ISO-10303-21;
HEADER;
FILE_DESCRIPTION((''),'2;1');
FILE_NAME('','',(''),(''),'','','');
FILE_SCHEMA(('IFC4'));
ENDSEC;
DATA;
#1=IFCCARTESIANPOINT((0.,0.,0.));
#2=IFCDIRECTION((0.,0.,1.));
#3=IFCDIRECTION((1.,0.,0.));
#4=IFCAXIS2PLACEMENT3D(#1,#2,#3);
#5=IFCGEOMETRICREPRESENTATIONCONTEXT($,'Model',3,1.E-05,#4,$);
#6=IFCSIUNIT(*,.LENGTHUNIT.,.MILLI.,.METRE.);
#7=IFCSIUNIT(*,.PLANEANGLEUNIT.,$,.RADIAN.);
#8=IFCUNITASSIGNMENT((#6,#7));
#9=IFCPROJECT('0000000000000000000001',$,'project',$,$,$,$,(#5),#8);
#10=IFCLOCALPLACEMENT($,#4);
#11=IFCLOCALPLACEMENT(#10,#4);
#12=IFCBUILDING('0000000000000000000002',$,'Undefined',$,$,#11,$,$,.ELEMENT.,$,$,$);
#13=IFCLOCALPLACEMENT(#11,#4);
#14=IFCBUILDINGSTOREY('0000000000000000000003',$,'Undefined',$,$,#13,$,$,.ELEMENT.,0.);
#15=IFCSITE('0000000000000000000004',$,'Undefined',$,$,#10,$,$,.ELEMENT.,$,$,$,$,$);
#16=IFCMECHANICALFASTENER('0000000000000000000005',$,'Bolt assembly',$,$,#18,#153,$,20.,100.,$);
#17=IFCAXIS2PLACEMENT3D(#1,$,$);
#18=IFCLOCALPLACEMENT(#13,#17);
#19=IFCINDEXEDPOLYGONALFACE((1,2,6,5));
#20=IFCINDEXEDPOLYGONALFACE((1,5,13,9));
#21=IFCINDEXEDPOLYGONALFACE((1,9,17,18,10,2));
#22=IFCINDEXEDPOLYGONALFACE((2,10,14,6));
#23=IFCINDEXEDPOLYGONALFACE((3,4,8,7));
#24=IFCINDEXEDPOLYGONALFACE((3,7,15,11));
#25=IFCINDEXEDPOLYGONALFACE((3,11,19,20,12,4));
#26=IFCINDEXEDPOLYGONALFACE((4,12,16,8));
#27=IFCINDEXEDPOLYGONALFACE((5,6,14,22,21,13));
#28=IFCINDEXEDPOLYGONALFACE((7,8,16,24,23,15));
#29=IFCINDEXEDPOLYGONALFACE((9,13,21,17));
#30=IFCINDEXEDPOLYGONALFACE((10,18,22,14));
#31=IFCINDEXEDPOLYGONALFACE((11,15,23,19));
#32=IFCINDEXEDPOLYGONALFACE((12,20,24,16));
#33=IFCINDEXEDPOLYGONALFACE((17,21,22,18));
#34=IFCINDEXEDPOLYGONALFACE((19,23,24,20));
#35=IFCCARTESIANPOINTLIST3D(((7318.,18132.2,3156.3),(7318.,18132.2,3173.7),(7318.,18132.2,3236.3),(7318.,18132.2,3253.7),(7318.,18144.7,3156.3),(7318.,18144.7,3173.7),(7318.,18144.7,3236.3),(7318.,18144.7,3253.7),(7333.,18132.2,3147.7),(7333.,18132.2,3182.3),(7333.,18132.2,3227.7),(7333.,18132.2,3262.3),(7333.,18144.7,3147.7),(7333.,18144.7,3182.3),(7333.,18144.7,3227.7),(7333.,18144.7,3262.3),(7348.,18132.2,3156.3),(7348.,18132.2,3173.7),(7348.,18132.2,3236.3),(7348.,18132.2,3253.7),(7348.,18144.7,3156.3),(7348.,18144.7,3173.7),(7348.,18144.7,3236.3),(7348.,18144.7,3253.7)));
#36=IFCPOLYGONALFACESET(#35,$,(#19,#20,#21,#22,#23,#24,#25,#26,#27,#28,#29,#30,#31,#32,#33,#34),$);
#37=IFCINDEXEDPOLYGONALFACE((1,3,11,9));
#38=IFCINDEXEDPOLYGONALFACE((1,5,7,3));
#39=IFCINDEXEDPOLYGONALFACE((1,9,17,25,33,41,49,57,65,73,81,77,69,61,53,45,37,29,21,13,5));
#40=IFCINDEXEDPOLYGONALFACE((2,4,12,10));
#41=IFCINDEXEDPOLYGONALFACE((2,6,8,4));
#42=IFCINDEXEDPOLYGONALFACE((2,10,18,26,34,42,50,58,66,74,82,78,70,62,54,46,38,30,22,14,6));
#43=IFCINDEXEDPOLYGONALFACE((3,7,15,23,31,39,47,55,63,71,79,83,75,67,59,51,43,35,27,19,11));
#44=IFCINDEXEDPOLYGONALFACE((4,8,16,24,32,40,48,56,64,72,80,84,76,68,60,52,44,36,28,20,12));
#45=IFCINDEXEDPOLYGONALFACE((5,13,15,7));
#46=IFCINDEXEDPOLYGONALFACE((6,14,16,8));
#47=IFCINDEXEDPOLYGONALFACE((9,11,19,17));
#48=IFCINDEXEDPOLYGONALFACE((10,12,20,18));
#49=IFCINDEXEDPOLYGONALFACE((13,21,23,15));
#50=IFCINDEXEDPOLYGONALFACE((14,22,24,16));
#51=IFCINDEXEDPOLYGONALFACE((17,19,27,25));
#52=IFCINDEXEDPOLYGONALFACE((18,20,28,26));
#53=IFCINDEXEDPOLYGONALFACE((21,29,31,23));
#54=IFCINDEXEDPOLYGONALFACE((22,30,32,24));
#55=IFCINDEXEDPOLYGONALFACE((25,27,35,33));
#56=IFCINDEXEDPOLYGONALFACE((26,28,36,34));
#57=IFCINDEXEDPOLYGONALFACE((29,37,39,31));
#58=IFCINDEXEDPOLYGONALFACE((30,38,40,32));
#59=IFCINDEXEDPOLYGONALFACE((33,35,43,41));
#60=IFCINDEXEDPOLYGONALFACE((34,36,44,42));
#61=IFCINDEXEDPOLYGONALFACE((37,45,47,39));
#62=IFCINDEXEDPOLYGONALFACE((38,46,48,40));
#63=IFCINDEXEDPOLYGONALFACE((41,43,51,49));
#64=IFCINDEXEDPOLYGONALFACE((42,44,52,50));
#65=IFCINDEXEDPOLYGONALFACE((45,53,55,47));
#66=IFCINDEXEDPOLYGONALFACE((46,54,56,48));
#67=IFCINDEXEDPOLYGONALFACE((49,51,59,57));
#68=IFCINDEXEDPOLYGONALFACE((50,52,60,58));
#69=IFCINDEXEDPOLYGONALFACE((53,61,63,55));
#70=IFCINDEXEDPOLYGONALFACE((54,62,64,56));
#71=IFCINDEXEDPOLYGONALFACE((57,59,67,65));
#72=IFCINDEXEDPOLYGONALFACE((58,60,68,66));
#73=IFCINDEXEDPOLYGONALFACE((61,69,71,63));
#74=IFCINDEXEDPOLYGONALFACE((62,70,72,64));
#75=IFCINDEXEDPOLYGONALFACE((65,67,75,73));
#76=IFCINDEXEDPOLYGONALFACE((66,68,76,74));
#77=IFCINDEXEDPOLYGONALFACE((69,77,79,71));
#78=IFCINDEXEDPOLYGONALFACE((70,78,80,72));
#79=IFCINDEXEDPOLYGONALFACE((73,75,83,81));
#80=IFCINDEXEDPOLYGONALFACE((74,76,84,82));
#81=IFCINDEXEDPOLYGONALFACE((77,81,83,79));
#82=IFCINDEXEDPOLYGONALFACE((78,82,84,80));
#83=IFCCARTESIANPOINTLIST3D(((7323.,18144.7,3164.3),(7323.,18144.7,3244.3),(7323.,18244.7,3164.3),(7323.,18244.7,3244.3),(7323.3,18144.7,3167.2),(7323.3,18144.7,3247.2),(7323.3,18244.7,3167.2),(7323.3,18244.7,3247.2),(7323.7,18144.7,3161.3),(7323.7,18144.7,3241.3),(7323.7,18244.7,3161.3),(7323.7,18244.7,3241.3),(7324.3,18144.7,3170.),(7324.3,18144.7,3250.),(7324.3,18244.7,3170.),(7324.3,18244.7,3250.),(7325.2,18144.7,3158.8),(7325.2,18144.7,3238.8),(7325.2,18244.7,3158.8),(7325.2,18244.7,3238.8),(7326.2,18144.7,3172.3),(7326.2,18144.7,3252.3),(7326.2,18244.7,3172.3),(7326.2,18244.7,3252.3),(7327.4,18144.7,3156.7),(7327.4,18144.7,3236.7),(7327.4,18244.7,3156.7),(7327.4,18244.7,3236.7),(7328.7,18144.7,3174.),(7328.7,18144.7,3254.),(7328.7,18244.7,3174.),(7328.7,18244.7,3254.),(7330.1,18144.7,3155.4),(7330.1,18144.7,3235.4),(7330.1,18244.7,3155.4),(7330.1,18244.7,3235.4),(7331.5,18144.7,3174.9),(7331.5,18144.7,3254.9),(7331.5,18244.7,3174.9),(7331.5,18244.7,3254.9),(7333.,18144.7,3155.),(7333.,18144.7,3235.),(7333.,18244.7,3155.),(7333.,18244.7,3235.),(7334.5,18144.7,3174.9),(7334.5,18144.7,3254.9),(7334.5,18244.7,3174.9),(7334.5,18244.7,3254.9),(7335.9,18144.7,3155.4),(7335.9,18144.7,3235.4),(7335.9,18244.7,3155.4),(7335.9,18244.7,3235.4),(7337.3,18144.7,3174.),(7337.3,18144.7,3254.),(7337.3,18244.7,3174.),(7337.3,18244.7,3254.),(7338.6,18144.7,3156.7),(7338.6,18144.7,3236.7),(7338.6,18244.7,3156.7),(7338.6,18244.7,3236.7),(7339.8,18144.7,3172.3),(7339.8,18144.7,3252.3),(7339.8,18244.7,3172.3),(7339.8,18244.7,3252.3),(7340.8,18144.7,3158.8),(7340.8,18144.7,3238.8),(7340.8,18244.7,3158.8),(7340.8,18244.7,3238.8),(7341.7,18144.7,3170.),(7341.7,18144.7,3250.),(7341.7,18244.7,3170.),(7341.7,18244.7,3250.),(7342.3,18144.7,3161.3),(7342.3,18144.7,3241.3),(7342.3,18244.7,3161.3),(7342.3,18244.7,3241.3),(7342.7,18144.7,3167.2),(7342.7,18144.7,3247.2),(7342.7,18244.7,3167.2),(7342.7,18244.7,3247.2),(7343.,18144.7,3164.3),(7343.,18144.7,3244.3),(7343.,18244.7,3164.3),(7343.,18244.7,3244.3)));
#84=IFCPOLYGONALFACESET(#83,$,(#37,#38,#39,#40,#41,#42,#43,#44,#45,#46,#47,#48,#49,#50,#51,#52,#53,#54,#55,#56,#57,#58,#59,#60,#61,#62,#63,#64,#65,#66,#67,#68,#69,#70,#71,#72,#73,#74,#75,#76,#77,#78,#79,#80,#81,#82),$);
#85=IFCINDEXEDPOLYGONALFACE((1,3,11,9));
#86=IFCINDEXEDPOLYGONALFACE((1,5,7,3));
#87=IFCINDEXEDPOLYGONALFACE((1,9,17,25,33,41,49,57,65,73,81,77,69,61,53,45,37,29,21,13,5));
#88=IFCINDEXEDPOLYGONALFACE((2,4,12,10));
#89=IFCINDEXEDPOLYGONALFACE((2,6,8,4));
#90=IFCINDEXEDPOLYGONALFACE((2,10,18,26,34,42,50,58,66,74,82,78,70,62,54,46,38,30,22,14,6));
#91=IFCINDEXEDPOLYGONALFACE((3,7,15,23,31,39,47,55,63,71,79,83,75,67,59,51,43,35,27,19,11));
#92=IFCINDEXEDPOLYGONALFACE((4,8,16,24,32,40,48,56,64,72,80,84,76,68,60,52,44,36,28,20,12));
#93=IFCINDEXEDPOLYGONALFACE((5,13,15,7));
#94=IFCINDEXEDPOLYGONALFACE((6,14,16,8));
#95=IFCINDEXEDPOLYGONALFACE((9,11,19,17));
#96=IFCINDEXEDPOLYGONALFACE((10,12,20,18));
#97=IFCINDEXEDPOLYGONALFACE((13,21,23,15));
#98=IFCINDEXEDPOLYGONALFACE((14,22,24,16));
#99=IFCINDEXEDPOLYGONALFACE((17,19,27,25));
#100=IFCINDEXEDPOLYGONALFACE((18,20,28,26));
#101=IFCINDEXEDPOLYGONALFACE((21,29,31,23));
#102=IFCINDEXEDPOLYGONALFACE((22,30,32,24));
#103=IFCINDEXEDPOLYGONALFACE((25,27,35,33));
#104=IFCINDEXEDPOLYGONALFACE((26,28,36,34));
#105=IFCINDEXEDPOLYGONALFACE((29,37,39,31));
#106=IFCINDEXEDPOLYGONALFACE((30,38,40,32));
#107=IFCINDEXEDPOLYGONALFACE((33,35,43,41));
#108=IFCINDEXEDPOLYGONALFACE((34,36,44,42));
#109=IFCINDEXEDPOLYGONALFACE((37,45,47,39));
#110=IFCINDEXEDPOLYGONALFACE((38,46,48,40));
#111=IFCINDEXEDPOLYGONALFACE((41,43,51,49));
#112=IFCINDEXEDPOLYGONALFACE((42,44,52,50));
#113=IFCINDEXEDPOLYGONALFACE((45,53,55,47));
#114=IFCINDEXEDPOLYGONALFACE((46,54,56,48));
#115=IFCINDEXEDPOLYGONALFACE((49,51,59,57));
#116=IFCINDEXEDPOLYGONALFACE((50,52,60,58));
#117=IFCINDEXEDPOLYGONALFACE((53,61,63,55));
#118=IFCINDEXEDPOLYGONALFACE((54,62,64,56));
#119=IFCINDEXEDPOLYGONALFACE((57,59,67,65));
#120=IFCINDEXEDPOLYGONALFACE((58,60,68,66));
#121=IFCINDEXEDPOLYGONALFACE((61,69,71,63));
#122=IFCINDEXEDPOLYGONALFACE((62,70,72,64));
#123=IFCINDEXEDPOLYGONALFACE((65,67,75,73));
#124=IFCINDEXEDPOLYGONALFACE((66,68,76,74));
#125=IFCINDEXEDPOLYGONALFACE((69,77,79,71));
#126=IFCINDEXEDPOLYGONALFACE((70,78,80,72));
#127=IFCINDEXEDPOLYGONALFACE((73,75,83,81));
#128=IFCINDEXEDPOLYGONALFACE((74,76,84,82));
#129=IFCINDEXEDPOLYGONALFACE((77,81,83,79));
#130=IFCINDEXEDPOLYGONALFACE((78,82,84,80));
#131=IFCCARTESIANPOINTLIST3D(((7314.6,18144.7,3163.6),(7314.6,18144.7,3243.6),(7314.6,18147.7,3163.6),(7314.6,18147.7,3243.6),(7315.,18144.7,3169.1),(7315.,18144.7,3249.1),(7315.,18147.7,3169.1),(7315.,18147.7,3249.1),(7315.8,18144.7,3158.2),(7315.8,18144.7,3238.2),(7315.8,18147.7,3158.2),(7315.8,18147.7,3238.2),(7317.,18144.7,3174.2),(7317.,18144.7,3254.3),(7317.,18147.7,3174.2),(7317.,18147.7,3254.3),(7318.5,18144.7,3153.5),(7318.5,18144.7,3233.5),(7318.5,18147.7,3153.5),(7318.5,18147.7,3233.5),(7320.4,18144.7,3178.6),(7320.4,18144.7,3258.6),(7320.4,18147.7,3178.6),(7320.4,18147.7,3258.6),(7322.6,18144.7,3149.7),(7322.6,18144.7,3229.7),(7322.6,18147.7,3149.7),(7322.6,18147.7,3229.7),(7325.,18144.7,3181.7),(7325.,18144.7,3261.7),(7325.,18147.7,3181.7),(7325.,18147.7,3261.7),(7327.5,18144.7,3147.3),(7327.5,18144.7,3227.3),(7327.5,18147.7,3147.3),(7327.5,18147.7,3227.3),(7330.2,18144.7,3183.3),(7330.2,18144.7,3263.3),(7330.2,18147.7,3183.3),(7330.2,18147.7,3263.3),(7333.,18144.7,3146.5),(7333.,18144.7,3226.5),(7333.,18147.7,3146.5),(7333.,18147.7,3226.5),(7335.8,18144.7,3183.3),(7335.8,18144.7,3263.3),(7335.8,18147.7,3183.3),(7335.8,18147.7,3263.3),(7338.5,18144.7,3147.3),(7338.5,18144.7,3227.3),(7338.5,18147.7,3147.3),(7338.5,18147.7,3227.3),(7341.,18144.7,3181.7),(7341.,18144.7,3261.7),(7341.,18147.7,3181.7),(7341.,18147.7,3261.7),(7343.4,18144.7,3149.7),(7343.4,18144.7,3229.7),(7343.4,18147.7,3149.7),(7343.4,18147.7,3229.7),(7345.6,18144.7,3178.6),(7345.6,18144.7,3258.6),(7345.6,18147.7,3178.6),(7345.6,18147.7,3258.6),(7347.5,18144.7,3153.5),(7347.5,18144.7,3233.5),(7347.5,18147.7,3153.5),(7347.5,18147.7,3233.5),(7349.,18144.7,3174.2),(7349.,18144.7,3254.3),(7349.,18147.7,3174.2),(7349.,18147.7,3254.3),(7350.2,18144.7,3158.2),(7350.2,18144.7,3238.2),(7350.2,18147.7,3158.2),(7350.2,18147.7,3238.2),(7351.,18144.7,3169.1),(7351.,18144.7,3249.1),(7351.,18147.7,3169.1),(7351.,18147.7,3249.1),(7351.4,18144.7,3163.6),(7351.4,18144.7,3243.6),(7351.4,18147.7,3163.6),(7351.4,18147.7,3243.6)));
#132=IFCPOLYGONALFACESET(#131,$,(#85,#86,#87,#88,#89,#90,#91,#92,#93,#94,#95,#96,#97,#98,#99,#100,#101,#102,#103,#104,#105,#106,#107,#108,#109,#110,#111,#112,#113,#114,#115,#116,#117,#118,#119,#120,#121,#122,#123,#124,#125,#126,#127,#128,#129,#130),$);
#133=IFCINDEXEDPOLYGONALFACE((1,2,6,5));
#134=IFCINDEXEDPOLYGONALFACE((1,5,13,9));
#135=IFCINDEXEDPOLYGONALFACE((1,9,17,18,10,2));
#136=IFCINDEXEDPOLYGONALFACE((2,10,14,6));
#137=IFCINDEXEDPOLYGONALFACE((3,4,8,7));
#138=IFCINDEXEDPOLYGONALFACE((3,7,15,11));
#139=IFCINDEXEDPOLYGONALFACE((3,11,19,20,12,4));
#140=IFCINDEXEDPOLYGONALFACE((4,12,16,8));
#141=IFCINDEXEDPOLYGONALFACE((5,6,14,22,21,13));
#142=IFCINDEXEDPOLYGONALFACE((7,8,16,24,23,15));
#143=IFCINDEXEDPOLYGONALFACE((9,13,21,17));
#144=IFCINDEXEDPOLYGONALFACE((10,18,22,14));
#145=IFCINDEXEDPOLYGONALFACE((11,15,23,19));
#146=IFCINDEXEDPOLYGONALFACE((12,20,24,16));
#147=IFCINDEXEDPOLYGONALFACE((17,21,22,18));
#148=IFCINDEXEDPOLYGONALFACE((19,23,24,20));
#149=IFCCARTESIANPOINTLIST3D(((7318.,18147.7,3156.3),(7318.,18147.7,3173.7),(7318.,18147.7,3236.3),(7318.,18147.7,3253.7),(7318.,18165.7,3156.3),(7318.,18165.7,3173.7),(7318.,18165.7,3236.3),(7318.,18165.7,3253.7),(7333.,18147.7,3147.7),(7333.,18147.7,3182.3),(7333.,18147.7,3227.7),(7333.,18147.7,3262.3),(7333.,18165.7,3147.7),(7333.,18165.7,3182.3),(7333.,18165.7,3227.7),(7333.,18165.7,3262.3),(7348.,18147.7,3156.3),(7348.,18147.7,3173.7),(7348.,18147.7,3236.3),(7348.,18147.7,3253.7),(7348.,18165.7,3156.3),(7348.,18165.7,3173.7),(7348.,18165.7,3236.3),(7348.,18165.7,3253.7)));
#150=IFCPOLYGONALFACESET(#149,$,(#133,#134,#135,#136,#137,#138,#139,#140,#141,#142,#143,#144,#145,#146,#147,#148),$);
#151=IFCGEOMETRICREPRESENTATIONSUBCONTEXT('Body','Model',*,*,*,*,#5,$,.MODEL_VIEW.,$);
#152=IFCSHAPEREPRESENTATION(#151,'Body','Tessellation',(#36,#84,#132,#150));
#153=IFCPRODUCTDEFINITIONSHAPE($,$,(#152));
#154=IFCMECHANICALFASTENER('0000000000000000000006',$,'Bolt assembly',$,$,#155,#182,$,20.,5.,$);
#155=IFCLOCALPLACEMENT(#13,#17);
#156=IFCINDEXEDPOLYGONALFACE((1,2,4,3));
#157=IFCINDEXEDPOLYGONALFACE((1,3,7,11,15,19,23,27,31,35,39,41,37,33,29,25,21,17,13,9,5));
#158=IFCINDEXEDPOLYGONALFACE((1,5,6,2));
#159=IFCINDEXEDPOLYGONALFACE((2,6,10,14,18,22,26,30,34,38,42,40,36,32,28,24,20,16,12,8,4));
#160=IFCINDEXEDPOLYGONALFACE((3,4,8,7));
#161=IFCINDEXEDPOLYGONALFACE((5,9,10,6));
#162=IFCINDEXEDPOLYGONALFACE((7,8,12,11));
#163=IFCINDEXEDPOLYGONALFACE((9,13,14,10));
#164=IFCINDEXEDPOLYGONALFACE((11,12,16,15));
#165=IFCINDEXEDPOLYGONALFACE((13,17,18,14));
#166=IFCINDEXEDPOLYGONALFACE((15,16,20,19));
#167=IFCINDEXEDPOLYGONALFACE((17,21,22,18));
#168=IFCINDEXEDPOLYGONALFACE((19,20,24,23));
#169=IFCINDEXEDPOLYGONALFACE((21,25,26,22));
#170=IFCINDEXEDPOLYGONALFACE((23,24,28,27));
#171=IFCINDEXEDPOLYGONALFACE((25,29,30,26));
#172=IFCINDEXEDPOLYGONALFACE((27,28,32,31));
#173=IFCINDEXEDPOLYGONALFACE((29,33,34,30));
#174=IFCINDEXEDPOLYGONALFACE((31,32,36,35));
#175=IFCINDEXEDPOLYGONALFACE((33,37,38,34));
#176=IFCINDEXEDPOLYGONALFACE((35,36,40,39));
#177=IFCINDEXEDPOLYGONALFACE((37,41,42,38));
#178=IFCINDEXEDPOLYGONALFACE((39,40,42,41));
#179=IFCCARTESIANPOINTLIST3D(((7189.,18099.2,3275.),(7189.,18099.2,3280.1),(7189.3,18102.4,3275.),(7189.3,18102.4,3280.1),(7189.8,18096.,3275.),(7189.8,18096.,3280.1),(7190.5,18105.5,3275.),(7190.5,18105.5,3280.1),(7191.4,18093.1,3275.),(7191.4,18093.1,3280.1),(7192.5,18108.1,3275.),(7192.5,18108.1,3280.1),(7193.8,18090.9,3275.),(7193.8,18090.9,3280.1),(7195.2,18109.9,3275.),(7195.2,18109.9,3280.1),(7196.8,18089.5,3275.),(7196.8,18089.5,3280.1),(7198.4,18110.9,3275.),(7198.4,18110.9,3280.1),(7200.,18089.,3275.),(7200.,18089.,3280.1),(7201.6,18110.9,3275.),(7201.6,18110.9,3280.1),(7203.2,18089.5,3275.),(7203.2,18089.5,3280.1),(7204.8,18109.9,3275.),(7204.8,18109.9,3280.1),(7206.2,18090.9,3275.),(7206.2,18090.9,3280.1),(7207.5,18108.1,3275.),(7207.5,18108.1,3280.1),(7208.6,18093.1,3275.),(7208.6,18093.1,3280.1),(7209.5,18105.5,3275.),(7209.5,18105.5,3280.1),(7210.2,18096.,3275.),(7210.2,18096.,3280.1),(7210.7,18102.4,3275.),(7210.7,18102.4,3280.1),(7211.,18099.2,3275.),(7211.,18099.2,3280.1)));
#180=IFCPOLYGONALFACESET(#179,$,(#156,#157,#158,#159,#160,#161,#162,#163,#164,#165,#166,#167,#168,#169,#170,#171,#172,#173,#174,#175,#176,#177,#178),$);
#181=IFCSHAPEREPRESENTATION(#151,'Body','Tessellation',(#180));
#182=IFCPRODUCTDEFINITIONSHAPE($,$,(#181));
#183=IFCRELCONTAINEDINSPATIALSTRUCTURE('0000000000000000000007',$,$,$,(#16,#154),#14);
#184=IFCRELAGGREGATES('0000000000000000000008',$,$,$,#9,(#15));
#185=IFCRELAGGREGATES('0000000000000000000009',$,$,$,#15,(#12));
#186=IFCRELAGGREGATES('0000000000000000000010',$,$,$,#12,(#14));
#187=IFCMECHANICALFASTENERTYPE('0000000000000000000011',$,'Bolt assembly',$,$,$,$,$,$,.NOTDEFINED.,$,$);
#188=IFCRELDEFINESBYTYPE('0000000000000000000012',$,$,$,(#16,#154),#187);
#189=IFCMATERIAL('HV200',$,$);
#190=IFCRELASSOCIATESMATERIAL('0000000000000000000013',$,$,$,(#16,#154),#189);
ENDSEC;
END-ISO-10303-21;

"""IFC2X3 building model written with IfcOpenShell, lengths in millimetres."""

from ifc_helpers import new_model, si_unit, frame, origin_with_axes, origin_2d_with_axis, place, context, subcontext, project, spatial, polyline, circle, outline, extrude, source, transform, mapped, material, type_object, element, save


model = new_model("IFC2X3")

# Units and contexts
model_context = context("Model", 3, precision=1e-05, world=origin_with_axes())
body_context = subcontext(model_context, "Body", "Model", "MODEL_VIEW")
ifc_project = project(units=[si_unit("LENGTHUNIT", "METRE", prefix="MILLI"), si_unit("PLANEANGLEUNIT", "RADIAN")], contexts=[model_context])

# Site, building, storey
site_placement = place(None, origin_with_axes())
site = spatial("IfcSite", under=ifc_project, at=site_placement, Name="Undefined", CompositionType="ELEMENT")
building_placement = place(site_placement, origin_with_axes())
building = spatial("IfcBuilding", under=site, at=building_placement, Name="Undefined", CompositionType="ELEMENT")
storey_placement = place(building_placement, origin_with_axes())
storey = spatial("IfcBuildingStorey", under=building, at=storey_placement, Name="Undefined", CompositionType="ELEMENT", Elevation=0.0)

# Mechanical fasteners
ifc_material_1 = material(Name="HV200")
mechanical_fastener_type = type_object("IfcMechanicalFastenerType", Name="Bolt assembly")
shared_shape_1 = source(origin_with_axes(), body_context, "Body", "SweptSolid", [
    extrude(outline(polyline([(17.3, 0.0), (8.7, 15.0), (-8.7, 15.0), (-17.3, 0.0), (-8.7, -15.0), (8.7, -15.0), (17.3, 0.0)])), frame((0.0, -12.5, 0.0), z_axis=(0.0, 1.0, 0.0), x_axis=(1.0, 0.0, 0.0)), (0.0, 0.0, 1.0), 12.5),
    extrude(circle(Radius=10.0, at=origin_2d_with_axis()), frame((0.0, 0.0, 0.0), z_axis=(0.0, 1.0, 0.0), x_axis=(1.0, 0.0, 0.0)), (0.0, 0.0, 1.0), 100.0),
    extrude(circle(Radius=18.5, at=origin_2d_with_axis()), frame((0.0, 0.0, 0.0), z_axis=(0.0, 1.0, 0.0), x_axis=(1.0, 0.0, 0.0)), (0.0, 0.0, 1.0), 3.0),
    extrude(outline(polyline([(17.3, 0.0), (8.7, 15.0), (-8.7, 15.0), (-17.3, 0.0), (-8.7, -15.0), (8.7, -15.0), (17.3, 0.0)])), frame((0.0, 3.0, 0.0), z_axis=(0.0, 1.0, 0.0), x_axis=(1.0, 0.0, 0.0)), (0.0, 0.0, 1.0), 18.0),
])
for number, where, z_axis, x_axis, name in (
    (1, (7333.0, 18144.7, 3245.0), (1.0, 0.0, 0.0), (0.0, 0.0, -1.0), "Bolt assembly"),
):
    element("IfcMechanicalFastener", number, at=place(storey_placement, frame(where, z_axis=z_axis, x_axis=x_axis)), inside=storey, type_object=mechanical_fastener_type, material=ifc_material_1, Name=name, NominalDiameter=20.0, NominalLength=100.0, context=body_context, shape_type="MappedRepresentation", body=[
        mapped(shared_shape_1, transform((0.0, 0.0, 0.0))),
        mapped(shared_shape_1, transform((80.0, 0.0, 0.0))),
    ])
shared_shape_2 = source(origin_with_axes(), body_context, "Body", "SweptSolid", [
    extrude(circle(Radius=11.0, at=origin_2d_with_axis()), frame((0.0, -5.0, 0.0), z_axis=(0.0, 1.0, 0.0), x_axis=(1.0, 0.0, 0.0)), (0.0, 0.0, 1.0), 5.1),
])
mechanical_fastener_placement = place(storey_placement, frame((7200.0, 18100.0, 3280.0), z_axis=(-1.0, 0.0, 0.0), x_axis=(0.0, -1.0, 0.0)))
element("IfcMechanicalFastener", 2, at=mechanical_fastener_placement, inside=storey, type_object=mechanical_fastener_type, material=ifc_material_1, Name="Bolt assembly", NominalDiameter=20.0, NominalLength=5.0, context=body_context, shape_type="MappedRepresentation", body=[
    mapped(shared_shape_2, transform((0.0, 0.0, 0.0))),
])

save(model, "model.ifc")
